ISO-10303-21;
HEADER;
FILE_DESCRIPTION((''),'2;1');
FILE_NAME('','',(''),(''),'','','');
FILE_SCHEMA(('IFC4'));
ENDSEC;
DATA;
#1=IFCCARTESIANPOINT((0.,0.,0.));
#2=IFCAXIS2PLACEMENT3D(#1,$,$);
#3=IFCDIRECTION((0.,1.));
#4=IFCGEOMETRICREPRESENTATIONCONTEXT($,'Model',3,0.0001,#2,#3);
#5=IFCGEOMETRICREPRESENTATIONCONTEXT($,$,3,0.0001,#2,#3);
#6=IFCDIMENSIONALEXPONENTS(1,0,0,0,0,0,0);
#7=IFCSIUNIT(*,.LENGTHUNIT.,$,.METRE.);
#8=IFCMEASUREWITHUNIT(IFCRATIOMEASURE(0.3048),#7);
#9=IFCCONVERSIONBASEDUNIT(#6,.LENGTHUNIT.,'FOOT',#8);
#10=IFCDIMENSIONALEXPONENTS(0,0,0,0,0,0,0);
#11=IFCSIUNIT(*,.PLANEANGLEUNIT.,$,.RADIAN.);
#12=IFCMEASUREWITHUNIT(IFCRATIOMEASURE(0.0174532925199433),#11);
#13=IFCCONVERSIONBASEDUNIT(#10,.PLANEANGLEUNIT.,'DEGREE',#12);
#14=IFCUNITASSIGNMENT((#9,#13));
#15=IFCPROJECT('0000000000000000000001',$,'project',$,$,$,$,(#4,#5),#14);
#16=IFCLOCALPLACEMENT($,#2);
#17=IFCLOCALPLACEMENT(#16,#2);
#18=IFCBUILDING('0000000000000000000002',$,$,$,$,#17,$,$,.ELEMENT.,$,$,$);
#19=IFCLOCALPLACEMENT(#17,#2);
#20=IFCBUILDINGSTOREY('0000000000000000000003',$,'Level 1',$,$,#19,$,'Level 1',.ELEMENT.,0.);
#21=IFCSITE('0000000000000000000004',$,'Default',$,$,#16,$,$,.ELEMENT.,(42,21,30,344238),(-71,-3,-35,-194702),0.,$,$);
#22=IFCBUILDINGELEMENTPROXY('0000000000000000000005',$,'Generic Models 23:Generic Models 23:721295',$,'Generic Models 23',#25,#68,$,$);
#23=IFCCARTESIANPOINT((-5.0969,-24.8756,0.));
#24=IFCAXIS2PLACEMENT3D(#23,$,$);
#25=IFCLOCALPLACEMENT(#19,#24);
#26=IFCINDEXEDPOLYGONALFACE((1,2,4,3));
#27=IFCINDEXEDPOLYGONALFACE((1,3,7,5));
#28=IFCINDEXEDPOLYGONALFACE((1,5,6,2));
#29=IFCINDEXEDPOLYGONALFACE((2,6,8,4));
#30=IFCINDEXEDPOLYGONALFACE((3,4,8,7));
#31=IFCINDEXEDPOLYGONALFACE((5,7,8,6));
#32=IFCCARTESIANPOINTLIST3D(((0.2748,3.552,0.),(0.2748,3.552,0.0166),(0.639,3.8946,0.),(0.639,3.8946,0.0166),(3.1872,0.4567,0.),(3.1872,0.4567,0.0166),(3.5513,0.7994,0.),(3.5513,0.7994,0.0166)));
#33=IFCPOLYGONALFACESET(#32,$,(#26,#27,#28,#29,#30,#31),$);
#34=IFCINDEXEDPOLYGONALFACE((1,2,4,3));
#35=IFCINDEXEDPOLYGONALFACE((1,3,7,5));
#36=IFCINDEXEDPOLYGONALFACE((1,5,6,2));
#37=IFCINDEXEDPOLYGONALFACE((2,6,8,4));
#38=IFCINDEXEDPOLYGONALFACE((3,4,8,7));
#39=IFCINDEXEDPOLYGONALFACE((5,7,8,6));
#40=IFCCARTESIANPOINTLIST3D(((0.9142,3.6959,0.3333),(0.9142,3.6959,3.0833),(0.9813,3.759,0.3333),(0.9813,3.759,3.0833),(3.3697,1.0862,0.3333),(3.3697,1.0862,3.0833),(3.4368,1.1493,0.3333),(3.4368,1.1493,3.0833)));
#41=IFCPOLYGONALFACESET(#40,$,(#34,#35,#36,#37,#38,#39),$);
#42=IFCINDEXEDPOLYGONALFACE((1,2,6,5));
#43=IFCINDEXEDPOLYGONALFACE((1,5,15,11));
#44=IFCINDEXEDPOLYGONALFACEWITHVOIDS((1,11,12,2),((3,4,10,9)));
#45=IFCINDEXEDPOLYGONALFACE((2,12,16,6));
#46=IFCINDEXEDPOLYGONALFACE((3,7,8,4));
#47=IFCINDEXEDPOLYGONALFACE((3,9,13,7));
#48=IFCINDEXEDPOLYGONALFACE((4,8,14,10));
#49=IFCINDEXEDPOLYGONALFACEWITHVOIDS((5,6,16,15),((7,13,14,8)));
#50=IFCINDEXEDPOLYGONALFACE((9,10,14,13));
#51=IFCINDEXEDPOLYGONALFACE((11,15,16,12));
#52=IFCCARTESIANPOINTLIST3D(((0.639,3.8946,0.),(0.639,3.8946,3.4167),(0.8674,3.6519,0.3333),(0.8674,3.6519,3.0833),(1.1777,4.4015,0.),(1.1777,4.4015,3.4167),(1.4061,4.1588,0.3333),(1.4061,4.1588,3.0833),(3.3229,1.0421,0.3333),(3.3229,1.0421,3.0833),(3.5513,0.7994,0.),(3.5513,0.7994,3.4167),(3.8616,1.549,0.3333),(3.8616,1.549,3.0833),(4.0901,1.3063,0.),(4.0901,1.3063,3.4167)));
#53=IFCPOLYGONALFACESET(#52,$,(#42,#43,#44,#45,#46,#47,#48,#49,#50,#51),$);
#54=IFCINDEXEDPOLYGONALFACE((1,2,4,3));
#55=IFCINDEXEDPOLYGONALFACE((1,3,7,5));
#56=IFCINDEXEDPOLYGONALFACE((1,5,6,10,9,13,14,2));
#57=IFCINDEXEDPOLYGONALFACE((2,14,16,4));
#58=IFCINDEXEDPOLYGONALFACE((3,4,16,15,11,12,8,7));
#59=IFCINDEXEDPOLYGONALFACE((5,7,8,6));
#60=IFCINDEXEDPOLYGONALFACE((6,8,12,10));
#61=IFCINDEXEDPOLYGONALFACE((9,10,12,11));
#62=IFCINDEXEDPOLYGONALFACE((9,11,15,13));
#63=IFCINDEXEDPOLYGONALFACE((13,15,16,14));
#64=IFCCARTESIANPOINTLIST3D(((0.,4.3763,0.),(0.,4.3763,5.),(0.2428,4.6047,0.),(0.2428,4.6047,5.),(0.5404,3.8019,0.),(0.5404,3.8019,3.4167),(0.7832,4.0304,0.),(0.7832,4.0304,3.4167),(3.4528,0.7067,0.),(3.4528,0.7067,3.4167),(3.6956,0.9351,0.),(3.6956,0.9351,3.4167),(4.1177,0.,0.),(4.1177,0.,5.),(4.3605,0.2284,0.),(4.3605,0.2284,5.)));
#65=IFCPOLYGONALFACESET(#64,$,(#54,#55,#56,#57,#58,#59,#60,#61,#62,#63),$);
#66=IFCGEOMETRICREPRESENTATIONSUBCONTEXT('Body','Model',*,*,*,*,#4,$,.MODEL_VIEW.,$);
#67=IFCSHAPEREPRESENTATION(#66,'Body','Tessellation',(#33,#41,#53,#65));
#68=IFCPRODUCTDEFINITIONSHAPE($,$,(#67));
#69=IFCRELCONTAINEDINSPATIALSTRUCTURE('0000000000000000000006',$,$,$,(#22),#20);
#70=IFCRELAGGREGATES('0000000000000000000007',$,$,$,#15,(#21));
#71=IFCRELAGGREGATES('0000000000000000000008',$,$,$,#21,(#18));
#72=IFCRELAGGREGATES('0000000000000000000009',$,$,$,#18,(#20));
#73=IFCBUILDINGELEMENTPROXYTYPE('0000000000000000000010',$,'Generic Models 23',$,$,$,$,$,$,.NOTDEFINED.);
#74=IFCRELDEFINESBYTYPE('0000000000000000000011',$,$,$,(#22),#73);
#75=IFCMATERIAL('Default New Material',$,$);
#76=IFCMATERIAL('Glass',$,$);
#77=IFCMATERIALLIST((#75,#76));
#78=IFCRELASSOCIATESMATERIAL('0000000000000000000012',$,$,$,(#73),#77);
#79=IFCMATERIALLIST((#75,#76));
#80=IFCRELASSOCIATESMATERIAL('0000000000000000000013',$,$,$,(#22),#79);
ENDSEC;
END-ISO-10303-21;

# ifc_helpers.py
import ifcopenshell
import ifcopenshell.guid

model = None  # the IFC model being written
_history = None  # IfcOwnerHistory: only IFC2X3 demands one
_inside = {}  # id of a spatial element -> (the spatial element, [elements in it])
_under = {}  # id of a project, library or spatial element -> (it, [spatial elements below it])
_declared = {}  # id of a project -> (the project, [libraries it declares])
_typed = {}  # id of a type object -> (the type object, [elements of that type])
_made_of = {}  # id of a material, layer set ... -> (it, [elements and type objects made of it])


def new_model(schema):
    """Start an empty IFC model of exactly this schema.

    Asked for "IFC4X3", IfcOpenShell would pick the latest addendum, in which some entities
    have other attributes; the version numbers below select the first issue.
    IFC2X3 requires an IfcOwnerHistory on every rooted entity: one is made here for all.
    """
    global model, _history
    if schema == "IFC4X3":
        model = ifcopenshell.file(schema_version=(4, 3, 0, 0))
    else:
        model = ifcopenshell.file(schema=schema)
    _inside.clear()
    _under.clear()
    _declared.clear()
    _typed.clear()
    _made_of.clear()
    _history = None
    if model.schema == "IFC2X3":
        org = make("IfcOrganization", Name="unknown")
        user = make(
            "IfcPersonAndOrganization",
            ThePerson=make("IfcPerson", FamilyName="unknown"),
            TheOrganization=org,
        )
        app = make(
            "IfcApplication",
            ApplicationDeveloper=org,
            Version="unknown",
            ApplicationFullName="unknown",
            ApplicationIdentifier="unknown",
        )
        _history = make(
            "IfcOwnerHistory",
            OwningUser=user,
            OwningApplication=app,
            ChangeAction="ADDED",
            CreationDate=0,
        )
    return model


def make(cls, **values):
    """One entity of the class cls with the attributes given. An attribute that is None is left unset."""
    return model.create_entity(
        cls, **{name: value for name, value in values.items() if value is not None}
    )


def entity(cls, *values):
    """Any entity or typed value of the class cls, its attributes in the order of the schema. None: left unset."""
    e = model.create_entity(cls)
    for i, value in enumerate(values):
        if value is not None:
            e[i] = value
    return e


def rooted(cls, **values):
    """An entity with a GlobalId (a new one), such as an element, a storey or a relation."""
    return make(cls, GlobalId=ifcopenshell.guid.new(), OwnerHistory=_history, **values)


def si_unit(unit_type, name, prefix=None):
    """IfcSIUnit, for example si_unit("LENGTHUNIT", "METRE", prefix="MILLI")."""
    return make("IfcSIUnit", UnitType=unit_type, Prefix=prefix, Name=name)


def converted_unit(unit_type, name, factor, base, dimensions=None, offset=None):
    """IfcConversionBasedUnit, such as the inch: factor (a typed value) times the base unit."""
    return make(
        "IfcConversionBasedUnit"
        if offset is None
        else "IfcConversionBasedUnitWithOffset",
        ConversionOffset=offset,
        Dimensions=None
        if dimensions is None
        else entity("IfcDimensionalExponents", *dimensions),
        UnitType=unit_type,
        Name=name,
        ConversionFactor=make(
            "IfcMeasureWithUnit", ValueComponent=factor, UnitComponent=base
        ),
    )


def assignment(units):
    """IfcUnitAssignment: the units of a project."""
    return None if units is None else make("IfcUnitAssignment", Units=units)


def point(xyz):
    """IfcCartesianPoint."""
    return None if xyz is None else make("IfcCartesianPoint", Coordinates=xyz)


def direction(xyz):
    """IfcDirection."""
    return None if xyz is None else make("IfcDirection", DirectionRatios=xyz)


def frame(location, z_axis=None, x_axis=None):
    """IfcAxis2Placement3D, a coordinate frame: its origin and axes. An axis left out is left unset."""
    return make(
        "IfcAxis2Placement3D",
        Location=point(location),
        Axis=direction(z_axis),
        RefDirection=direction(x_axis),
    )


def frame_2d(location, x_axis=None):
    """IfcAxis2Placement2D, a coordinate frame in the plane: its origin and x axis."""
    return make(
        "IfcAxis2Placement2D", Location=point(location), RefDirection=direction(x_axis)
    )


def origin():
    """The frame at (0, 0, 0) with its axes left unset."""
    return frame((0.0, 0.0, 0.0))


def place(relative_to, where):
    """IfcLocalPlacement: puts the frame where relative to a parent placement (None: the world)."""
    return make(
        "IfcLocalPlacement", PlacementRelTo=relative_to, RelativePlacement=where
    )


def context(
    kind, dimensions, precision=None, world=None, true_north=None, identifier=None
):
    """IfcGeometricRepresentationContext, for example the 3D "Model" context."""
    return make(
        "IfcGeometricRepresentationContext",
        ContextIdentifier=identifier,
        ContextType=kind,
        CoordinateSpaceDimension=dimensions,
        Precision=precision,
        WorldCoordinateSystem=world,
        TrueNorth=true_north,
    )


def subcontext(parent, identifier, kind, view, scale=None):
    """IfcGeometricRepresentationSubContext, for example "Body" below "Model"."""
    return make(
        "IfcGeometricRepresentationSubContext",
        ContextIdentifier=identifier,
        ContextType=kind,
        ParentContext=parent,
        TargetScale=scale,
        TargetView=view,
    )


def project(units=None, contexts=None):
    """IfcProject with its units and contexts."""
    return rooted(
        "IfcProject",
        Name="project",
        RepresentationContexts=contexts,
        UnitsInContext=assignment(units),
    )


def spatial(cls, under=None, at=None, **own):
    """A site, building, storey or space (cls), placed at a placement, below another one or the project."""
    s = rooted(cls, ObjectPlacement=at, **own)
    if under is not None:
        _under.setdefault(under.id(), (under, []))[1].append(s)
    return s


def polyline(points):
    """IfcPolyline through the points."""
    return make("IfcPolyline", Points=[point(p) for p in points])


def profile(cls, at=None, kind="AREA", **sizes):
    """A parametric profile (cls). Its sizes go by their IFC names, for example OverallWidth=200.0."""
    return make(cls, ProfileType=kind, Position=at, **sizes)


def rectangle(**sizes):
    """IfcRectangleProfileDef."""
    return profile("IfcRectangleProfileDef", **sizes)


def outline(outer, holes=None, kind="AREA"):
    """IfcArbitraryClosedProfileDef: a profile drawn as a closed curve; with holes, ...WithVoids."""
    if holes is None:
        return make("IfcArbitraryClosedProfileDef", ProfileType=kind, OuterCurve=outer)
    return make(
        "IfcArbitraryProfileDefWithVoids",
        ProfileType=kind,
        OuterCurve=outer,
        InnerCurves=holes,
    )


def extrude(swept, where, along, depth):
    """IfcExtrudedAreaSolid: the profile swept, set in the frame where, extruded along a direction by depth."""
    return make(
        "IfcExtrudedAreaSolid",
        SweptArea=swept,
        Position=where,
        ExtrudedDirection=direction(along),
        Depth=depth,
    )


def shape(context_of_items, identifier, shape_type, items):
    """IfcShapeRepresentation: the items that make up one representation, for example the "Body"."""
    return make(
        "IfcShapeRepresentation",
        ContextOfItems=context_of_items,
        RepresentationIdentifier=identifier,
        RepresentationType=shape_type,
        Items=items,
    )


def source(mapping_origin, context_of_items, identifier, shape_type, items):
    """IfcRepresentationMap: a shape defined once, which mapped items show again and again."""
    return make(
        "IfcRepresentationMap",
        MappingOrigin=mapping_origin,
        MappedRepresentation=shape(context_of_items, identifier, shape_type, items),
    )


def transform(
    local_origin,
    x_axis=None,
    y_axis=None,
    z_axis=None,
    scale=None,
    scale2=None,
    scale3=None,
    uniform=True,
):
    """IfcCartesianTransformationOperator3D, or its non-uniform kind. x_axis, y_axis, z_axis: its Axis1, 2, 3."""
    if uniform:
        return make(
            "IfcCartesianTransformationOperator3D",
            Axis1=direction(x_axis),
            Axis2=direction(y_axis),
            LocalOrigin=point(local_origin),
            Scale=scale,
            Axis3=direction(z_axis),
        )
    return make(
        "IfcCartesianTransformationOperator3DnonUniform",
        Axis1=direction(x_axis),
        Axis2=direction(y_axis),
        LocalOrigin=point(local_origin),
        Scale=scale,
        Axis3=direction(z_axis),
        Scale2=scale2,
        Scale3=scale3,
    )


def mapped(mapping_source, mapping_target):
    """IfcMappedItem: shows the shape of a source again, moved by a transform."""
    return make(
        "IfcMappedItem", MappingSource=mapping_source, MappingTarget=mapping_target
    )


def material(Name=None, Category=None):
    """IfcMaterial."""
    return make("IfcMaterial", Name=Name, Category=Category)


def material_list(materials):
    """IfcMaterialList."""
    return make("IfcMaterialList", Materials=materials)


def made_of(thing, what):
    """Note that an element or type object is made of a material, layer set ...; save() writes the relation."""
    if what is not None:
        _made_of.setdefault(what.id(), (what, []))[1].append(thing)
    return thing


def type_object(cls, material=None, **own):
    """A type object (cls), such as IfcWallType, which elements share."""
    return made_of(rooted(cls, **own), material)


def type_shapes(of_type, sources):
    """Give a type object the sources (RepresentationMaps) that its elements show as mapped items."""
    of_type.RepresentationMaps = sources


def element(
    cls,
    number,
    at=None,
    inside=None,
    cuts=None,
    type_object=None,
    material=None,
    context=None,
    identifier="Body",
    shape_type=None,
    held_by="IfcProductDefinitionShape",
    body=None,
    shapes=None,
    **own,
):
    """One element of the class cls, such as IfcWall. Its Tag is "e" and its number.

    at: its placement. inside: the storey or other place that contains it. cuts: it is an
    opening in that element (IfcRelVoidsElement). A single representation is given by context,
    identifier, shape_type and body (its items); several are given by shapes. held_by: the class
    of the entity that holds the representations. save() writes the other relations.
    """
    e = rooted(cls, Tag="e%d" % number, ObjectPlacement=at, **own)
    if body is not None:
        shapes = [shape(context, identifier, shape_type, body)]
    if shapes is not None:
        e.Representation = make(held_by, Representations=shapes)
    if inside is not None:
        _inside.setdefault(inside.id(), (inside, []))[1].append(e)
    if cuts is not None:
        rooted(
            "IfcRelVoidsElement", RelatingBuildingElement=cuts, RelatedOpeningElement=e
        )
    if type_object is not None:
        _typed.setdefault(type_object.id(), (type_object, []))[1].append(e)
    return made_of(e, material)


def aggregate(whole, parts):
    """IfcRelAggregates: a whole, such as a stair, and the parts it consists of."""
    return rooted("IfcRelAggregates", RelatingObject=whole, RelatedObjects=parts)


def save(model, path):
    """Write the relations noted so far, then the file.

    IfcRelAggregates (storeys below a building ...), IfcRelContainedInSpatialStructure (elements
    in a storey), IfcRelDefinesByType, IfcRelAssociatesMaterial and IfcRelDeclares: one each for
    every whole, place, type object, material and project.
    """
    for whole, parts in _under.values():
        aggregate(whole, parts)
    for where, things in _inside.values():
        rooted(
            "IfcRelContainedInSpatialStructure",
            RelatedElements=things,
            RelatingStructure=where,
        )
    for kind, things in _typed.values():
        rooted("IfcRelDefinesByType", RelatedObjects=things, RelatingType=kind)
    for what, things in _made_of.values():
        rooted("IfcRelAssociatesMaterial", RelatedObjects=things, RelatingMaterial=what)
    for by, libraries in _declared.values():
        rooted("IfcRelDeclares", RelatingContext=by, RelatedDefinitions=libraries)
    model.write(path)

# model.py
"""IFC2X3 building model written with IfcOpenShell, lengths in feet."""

from ifc_helpers import new_model, entity, si_unit, converted_unit, direction, frame, frame_2d, origin, place, context, subcontext, project, spatial, polyline, rectangle, outline, extrude, source, transform, mapped, material, material_list, type_object, type_shapes, element, save


model = new_model("IFC2X3")

# Units and contexts
model_context = context("Model", 3, precision=0.0001, world=origin(), true_north=direction((0.0, 1.0)))
context_of_model = context(None, 3, precision=0.0001, world=origin(), true_north=direction((0.0, 1.0)))
body_context = subcontext(model_context, "Body", "Model", "MODEL_VIEW")
ifc_project = project(units=[converted_unit("LENGTHUNIT", "FOOT", entity("IfcRatioMeasure", 0.3048), si_unit("LENGTHUNIT", "METRE"), dimensions=[1, 0, 0, 0, 0, 0, 0]), converted_unit("PLANEANGLEUNIT", "DEGREE", entity("IfcRatioMeasure", 0.0174532925199433), si_unit("PLANEANGLEUNIT", "RADIAN"), dimensions=[0, 0, 0, 0, 0, 0, 0])], contexts=[model_context, context_of_model])

# Site, building, storey
site_placement = place(None, origin())
site = spatial("IfcSite", under=ifc_project, at=site_placement, Name="Default", CompositionType="ELEMENT", RefLatitude=(42, 21, 30, 344238), RefLongitude=(-71, -3, -35, -194702), RefElevation=0.0)
building_placement = place(site_placement, origin())
building = spatial("IfcBuilding", under=site, at=building_placement, CompositionType="ELEMENT")
storey_placement = place(building_placement, origin())
storey = spatial("IfcBuildingStorey", under=building, at=storey_placement, Name="Level 1", LongName="Level 1", CompositionType="ELEMENT", Elevation=0.0)

# Shared definitions
ifc_material_1 = material(Name="Default New Material")

# Building element proxy
ifc_material_2 = material(Name="Glass")
ifc_material_list_1 = material_list([ifc_material_1, ifc_material_2])
ifc_material_list_2 = material_list([ifc_material_1, ifc_material_2])
building_element_proxy_type_1 = type_object("IfcBuildingElementProxyType", Name="Generic Models 23", PredefinedType="NOTDEFINED", material=ifc_material_list_2)
shared_shape_1 = source(origin(), body_context, "Body", "SweptSolid", [
    extrude(rectangle(XDim=4.25, YDim=0.5, at=frame_2d((0.0, 0.0), x_axis=(1.0, 0.0))), frame((1.9131, 2.1757, 0.0), z_axis=(0.0, 0.0, 1.0), x_axis=(-0.685261, 0.728297, 0.0)), (0.0, 0.0, 1.0), 0.0166),
    extrude(rectangle(XDim=0.0921, YDim=3.5833, at=frame_2d((0.0, 0.0), x_axis=(1.0, 0.0))), frame((2.1755, 2.4226, 0.3333), z_axis=(0.0, 0.0, 1.0), x_axis=(0.728297, 0.685261, 0.0)), (0.0, 0.0, 1.0), 2.75),
    extrude(outline(polyline([(-2.125, -1.7083), (2.125, -1.7083), (2.125, 1.7083), (-2.125, 1.7083), (-2.125, -1.7083)]), holes=[polyline([(-1.7917, 1.375), (1.7917, 1.375), (1.7917, -1.375), (-1.7917, -1.375), (-1.7917, 1.375)])]), frame((2.0951, 2.347, 1.7083), z_axis=(0.728297, 0.685261, 0.0), x_axis=(0.685261, -0.728297, 0.0)), (0.0, 0.0, 1.0), 0.7397),
    extrude(outline(polyline([(-2.1042, -2.9591), (2.8958, -2.9591), (2.8958, 3.0499), (-2.1042, 3.0499), (-2.1042, 2.0796), (1.3125, 2.0796), (1.3125, -2.1704), (-2.1042, -2.1704), (-2.1042, -2.9591)])), frame((2.0277, 2.2212, 2.1042), z_axis=(0.728297, 0.685261, 0.0), x_axis=(0.0, 0.0, 1.0)), (0.0, 0.0, 1.0), 0.3333),
])
type_shapes(building_element_proxy_type_1, [shared_shape_1])
proxy_1_placement = place(storey_placement, frame((-5.0969, -24.8756, 0.0)))
element("IfcBuildingElementProxy", 1, at=proxy_1_placement, inside=storey, type_object=building_element_proxy_type_1, material=ifc_material_list_1, Name="Generic Models 23:Generic Models 23:721295", ObjectType="Generic Models 23", context=body_context, shape_type="MappedRepresentation", body=[
    mapped(shared_shape_1, transform((0.0, 0.0, 0.0), scale=1.0)),
])

save(model, "model.ifc")
